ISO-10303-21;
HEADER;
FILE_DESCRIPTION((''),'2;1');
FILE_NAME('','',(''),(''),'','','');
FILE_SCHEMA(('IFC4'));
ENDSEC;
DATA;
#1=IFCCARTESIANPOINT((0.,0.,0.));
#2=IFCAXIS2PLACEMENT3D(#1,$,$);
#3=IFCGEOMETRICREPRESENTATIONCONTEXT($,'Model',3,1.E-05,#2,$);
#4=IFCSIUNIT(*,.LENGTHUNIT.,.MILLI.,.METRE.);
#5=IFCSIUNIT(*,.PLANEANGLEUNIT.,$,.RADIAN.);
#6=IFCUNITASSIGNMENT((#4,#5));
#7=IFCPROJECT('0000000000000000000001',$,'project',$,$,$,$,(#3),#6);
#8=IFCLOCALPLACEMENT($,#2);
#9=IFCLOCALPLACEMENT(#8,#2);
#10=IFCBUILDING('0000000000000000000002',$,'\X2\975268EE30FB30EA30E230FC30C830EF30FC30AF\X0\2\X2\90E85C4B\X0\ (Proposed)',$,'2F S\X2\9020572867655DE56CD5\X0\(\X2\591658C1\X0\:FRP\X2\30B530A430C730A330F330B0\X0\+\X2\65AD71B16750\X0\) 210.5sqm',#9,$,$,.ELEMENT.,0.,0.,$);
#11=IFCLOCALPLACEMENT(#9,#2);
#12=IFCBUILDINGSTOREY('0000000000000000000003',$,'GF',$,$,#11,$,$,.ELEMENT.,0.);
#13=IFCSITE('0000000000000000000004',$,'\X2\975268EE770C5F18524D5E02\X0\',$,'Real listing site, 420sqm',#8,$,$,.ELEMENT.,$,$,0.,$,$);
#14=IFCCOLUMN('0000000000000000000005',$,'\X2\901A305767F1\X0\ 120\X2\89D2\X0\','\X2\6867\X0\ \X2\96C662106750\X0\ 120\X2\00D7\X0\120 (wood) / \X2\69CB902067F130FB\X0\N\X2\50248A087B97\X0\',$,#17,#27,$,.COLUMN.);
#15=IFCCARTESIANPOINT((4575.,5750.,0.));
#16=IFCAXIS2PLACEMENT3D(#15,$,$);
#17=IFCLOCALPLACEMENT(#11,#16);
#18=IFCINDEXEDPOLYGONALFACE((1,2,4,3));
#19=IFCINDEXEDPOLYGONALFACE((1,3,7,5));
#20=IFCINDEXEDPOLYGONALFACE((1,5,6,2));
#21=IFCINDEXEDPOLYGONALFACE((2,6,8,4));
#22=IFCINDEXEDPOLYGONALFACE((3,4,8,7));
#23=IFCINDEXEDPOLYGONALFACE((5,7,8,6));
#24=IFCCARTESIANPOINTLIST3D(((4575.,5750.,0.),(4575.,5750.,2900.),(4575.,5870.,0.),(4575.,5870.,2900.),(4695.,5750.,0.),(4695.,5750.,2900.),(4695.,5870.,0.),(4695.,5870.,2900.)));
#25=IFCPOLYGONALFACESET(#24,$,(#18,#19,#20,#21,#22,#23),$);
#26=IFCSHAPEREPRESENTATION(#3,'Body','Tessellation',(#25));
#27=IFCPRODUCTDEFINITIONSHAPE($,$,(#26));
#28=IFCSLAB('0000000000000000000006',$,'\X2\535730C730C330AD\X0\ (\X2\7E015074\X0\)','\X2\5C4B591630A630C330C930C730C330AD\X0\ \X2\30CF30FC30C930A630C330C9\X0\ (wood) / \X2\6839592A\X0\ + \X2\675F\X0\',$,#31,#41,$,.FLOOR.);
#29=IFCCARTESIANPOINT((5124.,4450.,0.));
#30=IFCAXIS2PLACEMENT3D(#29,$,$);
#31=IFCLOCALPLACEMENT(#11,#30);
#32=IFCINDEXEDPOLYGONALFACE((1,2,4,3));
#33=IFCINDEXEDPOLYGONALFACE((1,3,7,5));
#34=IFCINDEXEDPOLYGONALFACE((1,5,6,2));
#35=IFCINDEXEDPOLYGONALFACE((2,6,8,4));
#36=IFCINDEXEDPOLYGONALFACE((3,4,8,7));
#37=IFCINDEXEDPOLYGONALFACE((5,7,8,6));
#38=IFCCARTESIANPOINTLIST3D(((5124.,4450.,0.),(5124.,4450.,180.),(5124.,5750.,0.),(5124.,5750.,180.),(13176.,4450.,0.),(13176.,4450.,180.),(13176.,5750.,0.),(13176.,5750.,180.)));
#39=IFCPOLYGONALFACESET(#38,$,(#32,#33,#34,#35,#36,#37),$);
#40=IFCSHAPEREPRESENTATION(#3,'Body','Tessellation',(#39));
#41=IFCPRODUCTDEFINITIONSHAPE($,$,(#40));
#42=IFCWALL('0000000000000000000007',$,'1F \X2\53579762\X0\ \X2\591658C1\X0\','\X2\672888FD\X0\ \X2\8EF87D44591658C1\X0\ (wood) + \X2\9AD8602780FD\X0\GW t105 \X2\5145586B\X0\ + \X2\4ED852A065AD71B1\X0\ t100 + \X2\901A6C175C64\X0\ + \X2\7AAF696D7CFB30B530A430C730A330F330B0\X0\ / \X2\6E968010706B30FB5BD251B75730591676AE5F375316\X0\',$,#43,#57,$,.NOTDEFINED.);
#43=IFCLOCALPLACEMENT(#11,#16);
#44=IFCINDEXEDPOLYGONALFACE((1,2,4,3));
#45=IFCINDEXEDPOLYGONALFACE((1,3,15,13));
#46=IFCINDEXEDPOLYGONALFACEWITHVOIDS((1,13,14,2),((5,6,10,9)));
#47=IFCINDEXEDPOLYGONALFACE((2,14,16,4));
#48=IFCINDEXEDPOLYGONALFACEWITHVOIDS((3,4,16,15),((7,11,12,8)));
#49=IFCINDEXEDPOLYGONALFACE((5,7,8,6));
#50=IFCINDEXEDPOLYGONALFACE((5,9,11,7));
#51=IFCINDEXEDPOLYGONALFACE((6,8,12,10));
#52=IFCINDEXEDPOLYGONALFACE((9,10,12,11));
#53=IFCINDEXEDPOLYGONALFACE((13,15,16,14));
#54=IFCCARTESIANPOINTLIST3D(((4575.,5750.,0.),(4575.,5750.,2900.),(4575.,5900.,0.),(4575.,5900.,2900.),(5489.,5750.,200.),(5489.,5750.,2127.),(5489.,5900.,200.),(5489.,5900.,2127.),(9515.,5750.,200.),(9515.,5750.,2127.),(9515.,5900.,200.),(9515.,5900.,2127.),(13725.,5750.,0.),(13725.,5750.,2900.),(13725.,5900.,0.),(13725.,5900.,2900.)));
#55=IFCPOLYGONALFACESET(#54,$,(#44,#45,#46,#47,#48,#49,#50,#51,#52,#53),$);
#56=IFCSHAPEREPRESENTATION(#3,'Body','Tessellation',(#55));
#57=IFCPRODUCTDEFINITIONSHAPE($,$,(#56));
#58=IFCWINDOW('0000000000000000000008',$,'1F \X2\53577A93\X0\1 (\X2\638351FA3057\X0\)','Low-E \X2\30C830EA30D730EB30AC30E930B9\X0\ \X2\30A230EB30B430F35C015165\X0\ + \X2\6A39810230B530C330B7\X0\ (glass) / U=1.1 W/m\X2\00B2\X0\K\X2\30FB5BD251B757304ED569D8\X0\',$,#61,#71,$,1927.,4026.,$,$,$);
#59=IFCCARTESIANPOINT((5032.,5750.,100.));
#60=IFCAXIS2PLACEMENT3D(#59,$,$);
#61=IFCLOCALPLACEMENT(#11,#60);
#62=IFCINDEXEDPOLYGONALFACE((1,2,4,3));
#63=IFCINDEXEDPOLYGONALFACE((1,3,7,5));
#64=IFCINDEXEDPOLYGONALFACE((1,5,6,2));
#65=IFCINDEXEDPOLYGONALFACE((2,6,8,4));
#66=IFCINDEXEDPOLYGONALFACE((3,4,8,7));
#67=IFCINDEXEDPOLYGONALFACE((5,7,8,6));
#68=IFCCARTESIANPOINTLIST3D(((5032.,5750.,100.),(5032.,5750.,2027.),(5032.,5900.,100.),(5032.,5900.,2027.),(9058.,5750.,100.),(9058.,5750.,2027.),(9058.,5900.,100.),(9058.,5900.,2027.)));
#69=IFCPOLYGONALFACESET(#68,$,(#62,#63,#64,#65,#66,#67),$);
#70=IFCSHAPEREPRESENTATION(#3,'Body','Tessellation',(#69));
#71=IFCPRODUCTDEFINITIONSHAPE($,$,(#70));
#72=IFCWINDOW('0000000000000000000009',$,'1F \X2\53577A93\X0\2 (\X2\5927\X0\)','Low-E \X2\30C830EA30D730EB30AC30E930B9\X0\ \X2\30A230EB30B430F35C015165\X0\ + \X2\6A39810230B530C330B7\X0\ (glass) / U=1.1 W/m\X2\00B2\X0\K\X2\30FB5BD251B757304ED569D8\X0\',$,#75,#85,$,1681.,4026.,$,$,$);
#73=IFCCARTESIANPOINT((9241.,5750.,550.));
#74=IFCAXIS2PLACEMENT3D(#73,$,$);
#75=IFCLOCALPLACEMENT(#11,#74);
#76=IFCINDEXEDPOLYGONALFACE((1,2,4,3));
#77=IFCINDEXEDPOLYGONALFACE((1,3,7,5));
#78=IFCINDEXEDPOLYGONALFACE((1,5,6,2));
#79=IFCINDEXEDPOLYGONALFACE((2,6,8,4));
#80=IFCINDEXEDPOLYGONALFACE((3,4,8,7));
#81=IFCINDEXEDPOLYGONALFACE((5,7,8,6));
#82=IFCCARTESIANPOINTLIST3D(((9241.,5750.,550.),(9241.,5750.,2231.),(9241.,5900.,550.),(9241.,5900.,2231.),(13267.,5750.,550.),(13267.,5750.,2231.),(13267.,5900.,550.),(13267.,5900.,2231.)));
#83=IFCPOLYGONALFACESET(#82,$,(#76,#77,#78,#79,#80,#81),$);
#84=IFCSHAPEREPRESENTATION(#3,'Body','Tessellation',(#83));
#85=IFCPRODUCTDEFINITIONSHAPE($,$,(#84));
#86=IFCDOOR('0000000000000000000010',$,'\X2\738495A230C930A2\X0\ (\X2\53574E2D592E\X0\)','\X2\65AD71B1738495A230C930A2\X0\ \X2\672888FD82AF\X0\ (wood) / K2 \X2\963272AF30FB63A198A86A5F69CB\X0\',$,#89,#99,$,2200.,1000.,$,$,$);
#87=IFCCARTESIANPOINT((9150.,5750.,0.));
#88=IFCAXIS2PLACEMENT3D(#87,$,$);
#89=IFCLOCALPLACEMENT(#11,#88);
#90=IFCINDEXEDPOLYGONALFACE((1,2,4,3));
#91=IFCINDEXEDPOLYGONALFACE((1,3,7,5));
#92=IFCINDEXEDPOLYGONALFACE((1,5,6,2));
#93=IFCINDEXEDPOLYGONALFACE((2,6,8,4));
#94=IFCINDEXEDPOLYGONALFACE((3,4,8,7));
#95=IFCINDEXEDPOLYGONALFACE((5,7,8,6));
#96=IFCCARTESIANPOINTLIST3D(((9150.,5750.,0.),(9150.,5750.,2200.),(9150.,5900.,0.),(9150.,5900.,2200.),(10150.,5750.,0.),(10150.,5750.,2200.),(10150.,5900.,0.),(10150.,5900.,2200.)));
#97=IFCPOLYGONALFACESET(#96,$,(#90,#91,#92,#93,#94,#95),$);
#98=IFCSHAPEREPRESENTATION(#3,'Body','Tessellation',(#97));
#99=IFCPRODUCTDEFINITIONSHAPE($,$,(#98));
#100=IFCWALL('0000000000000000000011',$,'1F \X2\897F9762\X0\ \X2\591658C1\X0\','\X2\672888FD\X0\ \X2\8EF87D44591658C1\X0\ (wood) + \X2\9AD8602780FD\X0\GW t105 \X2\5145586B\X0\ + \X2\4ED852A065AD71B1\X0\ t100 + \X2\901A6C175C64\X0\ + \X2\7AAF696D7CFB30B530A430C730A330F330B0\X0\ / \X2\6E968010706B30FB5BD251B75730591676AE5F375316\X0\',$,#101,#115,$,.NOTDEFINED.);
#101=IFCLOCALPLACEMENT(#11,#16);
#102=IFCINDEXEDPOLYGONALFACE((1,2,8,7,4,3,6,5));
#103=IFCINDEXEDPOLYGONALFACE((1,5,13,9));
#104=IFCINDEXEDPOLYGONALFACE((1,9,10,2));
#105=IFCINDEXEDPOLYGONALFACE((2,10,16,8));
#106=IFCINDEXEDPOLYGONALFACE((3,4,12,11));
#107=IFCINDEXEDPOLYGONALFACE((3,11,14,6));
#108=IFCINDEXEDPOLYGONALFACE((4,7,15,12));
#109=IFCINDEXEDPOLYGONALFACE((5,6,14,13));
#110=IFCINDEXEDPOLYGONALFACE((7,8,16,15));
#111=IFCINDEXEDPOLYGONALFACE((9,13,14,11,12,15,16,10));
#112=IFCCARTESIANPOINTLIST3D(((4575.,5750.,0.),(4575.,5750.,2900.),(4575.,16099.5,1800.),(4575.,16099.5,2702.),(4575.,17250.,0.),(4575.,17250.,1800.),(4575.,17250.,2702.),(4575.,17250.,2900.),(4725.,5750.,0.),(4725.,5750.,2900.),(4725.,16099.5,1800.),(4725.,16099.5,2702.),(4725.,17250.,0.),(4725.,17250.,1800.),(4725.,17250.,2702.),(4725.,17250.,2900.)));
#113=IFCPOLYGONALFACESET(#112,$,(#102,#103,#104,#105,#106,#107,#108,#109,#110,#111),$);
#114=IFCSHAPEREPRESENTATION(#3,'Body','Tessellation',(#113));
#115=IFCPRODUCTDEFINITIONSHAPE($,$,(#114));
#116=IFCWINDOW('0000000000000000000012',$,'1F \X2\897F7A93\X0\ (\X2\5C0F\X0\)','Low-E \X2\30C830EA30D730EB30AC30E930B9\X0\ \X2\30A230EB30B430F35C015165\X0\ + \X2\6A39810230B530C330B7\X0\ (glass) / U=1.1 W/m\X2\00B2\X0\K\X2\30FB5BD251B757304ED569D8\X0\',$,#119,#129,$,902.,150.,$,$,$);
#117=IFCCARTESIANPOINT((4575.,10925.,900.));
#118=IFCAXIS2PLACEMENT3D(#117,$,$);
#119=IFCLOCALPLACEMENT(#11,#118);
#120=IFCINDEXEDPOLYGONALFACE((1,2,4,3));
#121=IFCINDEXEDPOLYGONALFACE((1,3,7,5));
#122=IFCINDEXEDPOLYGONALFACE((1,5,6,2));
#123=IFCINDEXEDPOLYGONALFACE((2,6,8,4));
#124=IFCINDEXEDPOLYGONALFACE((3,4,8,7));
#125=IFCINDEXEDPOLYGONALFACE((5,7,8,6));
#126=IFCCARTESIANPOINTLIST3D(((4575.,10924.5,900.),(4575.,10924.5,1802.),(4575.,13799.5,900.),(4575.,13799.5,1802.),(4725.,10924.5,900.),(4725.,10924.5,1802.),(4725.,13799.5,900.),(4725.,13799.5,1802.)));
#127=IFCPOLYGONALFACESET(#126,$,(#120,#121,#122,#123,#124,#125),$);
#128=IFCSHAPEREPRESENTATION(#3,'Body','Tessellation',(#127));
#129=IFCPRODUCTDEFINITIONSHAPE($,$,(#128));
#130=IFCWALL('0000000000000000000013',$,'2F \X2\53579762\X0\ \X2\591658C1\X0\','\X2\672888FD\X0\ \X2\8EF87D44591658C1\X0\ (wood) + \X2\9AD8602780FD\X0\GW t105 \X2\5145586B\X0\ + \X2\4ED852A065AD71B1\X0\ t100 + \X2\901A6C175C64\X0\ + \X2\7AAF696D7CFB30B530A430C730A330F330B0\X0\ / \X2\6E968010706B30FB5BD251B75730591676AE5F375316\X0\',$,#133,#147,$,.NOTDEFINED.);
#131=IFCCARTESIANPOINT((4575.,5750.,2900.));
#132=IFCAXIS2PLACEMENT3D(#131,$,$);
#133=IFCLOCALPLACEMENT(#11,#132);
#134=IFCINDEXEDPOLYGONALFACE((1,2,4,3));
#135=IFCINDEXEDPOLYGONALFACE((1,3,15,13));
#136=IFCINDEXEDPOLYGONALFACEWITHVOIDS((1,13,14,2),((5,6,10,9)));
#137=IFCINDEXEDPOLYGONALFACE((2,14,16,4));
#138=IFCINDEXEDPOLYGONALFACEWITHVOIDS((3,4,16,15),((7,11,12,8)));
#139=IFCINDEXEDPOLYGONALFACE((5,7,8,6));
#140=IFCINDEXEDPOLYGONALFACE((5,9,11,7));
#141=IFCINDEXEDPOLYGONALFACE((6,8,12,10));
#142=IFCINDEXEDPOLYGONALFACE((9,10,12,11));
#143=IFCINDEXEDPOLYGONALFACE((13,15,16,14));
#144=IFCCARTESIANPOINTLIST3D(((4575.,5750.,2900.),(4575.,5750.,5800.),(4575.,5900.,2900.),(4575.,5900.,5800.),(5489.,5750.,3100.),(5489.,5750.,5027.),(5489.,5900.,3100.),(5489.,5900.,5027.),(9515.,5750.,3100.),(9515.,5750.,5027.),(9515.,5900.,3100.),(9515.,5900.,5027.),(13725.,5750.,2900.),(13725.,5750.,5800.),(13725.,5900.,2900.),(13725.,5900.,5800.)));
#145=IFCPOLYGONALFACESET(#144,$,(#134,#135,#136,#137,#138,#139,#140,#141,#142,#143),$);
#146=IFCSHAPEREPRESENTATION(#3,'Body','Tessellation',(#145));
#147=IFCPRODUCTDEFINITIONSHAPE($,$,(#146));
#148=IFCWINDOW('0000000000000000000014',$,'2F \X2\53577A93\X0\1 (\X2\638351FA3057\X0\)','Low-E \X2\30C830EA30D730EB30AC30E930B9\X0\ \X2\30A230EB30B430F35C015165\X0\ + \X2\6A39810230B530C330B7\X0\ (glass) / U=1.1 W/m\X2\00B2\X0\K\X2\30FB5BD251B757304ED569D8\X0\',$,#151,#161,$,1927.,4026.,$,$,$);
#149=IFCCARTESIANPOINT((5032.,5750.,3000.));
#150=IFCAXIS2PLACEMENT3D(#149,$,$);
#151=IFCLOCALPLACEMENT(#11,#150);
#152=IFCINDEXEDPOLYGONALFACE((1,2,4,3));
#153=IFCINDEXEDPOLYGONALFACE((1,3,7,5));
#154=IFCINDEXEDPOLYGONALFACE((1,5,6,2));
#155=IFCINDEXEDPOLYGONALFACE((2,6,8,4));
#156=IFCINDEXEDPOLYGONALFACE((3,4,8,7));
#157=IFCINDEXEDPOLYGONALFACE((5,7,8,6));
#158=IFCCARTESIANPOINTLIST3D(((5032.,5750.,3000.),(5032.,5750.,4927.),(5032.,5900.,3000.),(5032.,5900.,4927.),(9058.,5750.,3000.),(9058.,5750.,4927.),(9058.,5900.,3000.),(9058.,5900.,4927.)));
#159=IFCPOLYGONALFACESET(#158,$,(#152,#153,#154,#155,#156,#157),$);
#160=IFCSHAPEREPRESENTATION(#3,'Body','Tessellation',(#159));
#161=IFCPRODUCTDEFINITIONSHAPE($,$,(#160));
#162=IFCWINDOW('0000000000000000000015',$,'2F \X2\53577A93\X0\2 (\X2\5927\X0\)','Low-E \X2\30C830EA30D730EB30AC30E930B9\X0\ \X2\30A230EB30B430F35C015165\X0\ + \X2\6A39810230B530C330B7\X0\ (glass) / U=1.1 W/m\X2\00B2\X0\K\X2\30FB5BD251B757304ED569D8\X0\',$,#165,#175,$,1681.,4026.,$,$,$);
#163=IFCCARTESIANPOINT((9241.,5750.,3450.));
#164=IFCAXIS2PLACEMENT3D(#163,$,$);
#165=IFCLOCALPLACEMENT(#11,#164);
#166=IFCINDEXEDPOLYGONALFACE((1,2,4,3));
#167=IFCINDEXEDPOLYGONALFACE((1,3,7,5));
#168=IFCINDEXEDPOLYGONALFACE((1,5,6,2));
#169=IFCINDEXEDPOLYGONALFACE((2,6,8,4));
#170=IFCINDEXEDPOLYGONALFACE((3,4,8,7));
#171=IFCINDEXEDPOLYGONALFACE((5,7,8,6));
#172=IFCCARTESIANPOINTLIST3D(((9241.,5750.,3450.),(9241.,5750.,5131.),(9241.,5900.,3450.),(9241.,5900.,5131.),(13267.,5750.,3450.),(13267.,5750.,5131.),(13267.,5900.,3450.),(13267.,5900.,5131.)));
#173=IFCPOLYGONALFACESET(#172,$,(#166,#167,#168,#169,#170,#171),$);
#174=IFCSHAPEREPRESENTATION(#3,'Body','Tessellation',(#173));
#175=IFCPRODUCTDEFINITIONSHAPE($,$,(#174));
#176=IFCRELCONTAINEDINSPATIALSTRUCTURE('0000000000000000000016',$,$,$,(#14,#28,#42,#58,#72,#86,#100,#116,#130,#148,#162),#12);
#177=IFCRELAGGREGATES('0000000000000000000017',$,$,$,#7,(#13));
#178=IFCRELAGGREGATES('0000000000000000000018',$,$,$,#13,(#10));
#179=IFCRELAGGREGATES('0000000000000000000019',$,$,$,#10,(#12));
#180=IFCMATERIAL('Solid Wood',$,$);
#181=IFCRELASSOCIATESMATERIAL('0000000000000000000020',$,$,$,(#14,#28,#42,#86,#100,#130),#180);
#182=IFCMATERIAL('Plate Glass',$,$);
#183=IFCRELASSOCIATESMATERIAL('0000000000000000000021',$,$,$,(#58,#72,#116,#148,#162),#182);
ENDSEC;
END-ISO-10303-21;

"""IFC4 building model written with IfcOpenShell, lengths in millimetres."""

from ifc_helpers import new_model, si_unit, frame, frame_2d, origin, place, context, project, spatial, rectangle, extrude, material, element, fill, save


model = new_model("IFC4")

# Units and contexts
model_context = context("Model", 3, precision=1e-05, world=origin())
ifc_project = project(units=[si_unit("LENGTHUNIT", "METRE", prefix="MILLI"), si_unit("PLANEANGLEUNIT", "RADIAN")], contexts=[model_context])

# Site, building, storey
site_placement = place(None, origin())
site = spatial("IfcSite", under=ifc_project, at=site_placement, Name="青森県弘前市", ObjectType="Real listing site, 420sqm", CompositionType="ELEMENT", RefElevation=0.0)
building_placement = place(site_placement, origin())
building = spatial("IfcBuilding", under=site, at=building_placement, Name="青森・リモートワーク2部屋 (Proposed)", ObjectType="2F S造在来工法(外壁:FRPサイディング+断熱材) 210.5sqm", CompositionType="ELEMENT", ElevationOfRefHeight=0.0, ElevationOfTerrain=0.0)
storey_placement = place(building_placement, origin())
storey = spatial("IfcBuildingStorey", under=building, at=storey_placement, Name="GF", CompositionType="ELEMENT", Elevation=0.0)

# Column
ifc_material_1 = material(Name="Solid Wood")
column_placement = place(storey_placement, frame((4575.0, 5750.0, 0.0)))
element("IfcColumn", 1, at=column_placement, inside=storey, material=ifc_material_1, Name="通し柱 120角", Description="桧 集成材 120×120 (wood) / 構造柱・N値計算", PredefinedType="COLUMN", context=model_context, shape_type="SweptSolid", body=[
    extrude(rectangle(XDim=120.0, YDim=120.0, at=frame_2d((60.0, 60.0))), frame((4575.0, 5750.0, 0.0)), (0.0, 0.0, 1.0), 2900.0),
])

# Slab
slab_1_placement = place(storey_placement, frame((5124.0, 4450.0, 0.0)))
element("IfcSlab", 2, at=slab_1_placement, inside=storey, material=ifc_material_1, Name="南デッキ (縁側)", Description="屋外ウッドデッキ ハードウッド (wood) / 根太 + 束", PredefinedType="FLOOR", context=model_context, shape_type="SweptSolid", body=[
    extrude(rectangle(XDim=8052.0, YDim=1300.0, at=frame_2d((4026.0, 650.0))), frame((5124.0, 4450.0, 0.0)), (0.0, 0.0, 1.0), 180.0),
])

# Wall, openings, windows, door
wall_1_placement = place(storey_placement, frame((4575.0, 5750.0, 0.0)))
wall_1 = element("IfcWall", 3, at=wall_1_placement, inside=storey, material=ifc_material_1, Name="1F 南面 外壁", Description="木製 軸組外壁 (wood) + 高性能GW t105 充填 + 付加断熱 t100 + 通気層 + 窯業系サイディング / 準耐火・寒冷地外皮強化", PredefinedType="NOTDEFINED", context=model_context, shape_type="SweptSolid", body=[
    extrude(rectangle(XDim=9150.0, YDim=150.0, at=frame_2d((4575.0, 75.0))), frame((4575.0, 5750.0, 0.0)), (0.0, 0.0, 1.0), 2900.0),
])
opening_1_placement = place(storey_placement, frame((5032.0, 5750.0, 100.0)))
opening_1 = element("IfcOpeningElement", 4, at=opening_1_placement, cuts=wall_1, PredefinedType="NOTDEFINED", context=model_context, shape_type="SweptSolid", body=[
    extrude(rectangle(XDim=4026.0, YDim=150.0, at=frame_2d((2013.0, 75.0))), frame((5032.0, 5750.0, 100.0)), (0.0, 0.0, 1.0), 1927.0),
])
opening_2_placement = place(storey_placement, frame((9241.0, 5750.0, 550.0)))
opening_2 = element("IfcOpeningElement", 5, at=opening_2_placement, cuts=wall_1, PredefinedType="NOTDEFINED", context=model_context, shape_type="SweptSolid", body=[
    extrude(rectangle(XDim=4026.0, YDim=150.0, at=frame_2d((2013.0, 75.0))), frame((9241.0, 5750.0, 550.0)), (0.0, 0.0, 1.0), 1681.0),
])
opening_3_placement = place(storey_placement, frame((9150.0, 5750.0, 0.0)))
opening_3 = element("IfcOpeningElement", 6, at=opening_3_placement, cuts=wall_1, PredefinedType="NOTDEFINED", context=model_context, shape_type="SweptSolid", body=[
    extrude(rectangle(XDim=1000.0, YDim=150.0, at=frame_2d((500.0, 75.0))), frame((9150.0, 5750.0, 0.0)), (0.0, 0.0, 1.0), 2200.0),
])
ifc_material_2 = material(Name="Plate Glass")
window_1_placement = place(storey_placement, frame((5032.0, 5750.0, 100.0)))
window_1 = element("IfcWindow", 7, at=window_1_placement, inside=storey, material=ifc_material_2, Name="1F 南窓1 (掃出し)", Description="Low-E トリプルガラス アルゴン封入 + 樹脂サッシ (glass) / U=1.1 W/m²K・寒冷地仕様", OverallHeight=1927.0, OverallWidth=4026.0, context=model_context, shape_type="SweptSolid", body=[
    extrude(rectangle(XDim=4026.0, YDim=150.0, at=frame_2d((2013.0, 75.0))), frame((5032.0, 5750.0, 100.0)), (0.0, 0.0, 1.0), 1927.0),
])
fill(opening_1, window_1)
window_2_placement = place(storey_placement, frame((9241.0, 5750.0, 550.0)))
window_2 = element("IfcWindow", 8, at=window_2_placement, inside=storey, material=ifc_material_2, Name="1F 南窓2 (大)", Description="Low-E トリプルガラス アルゴン封入 + 樹脂サッシ (glass) / U=1.1 W/m²K・寒冷地仕様", OverallHeight=1681.0, OverallWidth=4026.0, context=model_context, shape_type="SweptSolid", body=[
    extrude(rectangle(XDim=4026.0, YDim=150.0, at=frame_2d((2013.0, 75.0))), frame((9241.0, 5750.0, 550.0)), (0.0, 0.0, 1.0), 1681.0),
])
fill(opening_2, window_2)
door_placement = place(storey_placement, frame((9150.0, 5750.0, 0.0)))
door = element("IfcDoor", 9, at=door_placement, inside=storey, material=ifc_material_1, Name="玄関ドア (南中央)", Description="断熱玄関ドア 木製芯 (wood) / K2 防犯・採風機構", OverallHeight=2200.0, OverallWidth=1000.0, context=model_context, shape_type="SweptSolid", body=[
    extrude(rectangle(XDim=1000.0, YDim=150.0, at=frame_2d((500.0, 75.0))), frame((9150.0, 5750.0, 0.0)), (0.0, 0.0, 1.0), 2200.0),
])
fill(opening_3, door)

# Wall, opening, window
wall_2_placement = place(storey_placement, frame((4575.0, 5750.0, 0.0)))
wall_2 = element("IfcWall", 10, at=wall_2_placement, inside=storey, material=ifc_material_1, Name="1F 西面 外壁", Description="木製 軸組外壁 (wood) + 高性能GW t105 充填 + 付加断熱 t100 + 通気層 + 窯業系サイディング / 準耐火・寒冷地外皮強化", PredefinedType="NOTDEFINED", context=model_context, shape_type="SweptSolid", body=[
    extrude(rectangle(XDim=150.0, YDim=11500.0, at=frame_2d((75.0, 5750.0))), frame((4575.0, 5750.0, 0.0)), (0.0, 0.0, 1.0), 2900.0),
])
opening_4_placement = place(storey_placement, frame((4575.0, 10925.0, 900.0)))
opening_4 = element("IfcOpeningElement", 11, at=opening_4_placement, cuts=wall_2, PredefinedType="NOTDEFINED", context=model_context, shape_type="SweptSolid", body=[
    extrude(rectangle(XDim=150.0, YDim=2875.0, at=frame_2d((75.0, 1437.0))), frame((4575.0, 10925.0, 900.0)), (0.0, 0.0, 1.0), 902.0),
])
window_3_placement = place(storey_placement, frame((4575.0, 10925.0, 900.0)))
window_3 = element("IfcWindow", 12, at=window_3_placement, inside=storey, material=ifc_material_2, Name="1F 西窓 (小)", Description="Low-E トリプルガラス アルゴン封入 + 樹脂サッシ (glass) / U=1.1 W/m²K・寒冷地仕様", OverallHeight=902.0, OverallWidth=150.0, context=model_context, shape_type="SweptSolid", body=[
    extrude(rectangle(XDim=150.0, YDim=2875.0, at=frame_2d((75.0, 1437.0))), frame((4575.0, 10925.0, 900.0)), (0.0, 0.0, 1.0), 902.0),
])
fill(opening_4, window_3)

# Wall, openings, windows
wall_3_placement = place(storey_placement, frame((4575.0, 5750.0, 2900.0)))
wall_3 = element("IfcWall", 13, at=wall_3_placement, inside=storey, material=ifc_material_1, Name="2F 南面 外壁", Description="木製 軸組外壁 (wood) + 高性能GW t105 充填 + 付加断熱 t100 + 通気層 + 窯業系サイディング / 準耐火・寒冷地外皮強化", PredefinedType="NOTDEFINED", context=model_context, shape_type="SweptSolid", body=[
    extrude(rectangle(XDim=9150.0, YDim=150.0, at=frame_2d((4575.0, 75.0))), frame((4575.0, 5750.0, 2900.0)), (0.0, 0.0, 1.0), 2900.0),
])
opening_5_placement = place(storey_placement, frame((5032.0, 5750.0, 3000.0)))
opening_5 = element("IfcOpeningElement", 14, at=opening_5_placement, cuts=wall_3, PredefinedType="NOTDEFINED", context=model_context, shape_type="SweptSolid", body=[
    extrude(rectangle(XDim=4026.0, YDim=150.0, at=frame_2d((2013.0, 75.0))), frame((5032.0, 5750.0, 3000.0)), (0.0, 0.0, 1.0), 1927.0),
])
opening_6_placement = place(storey_placement, frame((9241.0, 5750.0, 3450.0)))
opening_6 = element("IfcOpeningElement", 15, at=opening_6_placement, cuts=wall_3, PredefinedType="NOTDEFINED", context=model_context, shape_type="SweptSolid", body=[
    extrude(rectangle(XDim=4026.0, YDim=150.0, at=frame_2d((2013.0, 75.0))), frame((9241.0, 5750.0, 3450.0)), (0.0, 0.0, 1.0), 1681.0),
])
window_4_placement = place(storey_placement, frame((5032.0, 5750.0, 3000.0)))
window_4 = element("IfcWindow", 16, at=window_4_placement, inside=storey, material=ifc_material_2, Name="2F 南窓1 (掃出し)", Description="Low-E トリプルガラス アルゴン封入 + 樹脂サッシ (glass) / U=1.1 W/m²K・寒冷地仕様", OverallHeight=1927.0, OverallWidth=4026.0, context=model_context, shape_type="SweptSolid", body=[
    extrude(rectangle(XDim=4026.0, YDim=150.0, at=frame_2d((2013.0, 75.0))), frame((5032.0, 5750.0, 3000.0)), (0.0, 0.0, 1.0), 1927.0),
])
fill(opening_5, window_4)
window_5_placement = place(storey_placement, frame((9241.0, 5750.0, 3450.0)))
window_5 = element("IfcWindow", 17, at=window_5_placement, inside=storey, material=ifc_material_2, Name="2F 南窓2 (大)", Description="Low-E トリプルガラス アルゴン封入 + 樹脂サッシ (glass) / U=1.1 W/m²K・寒冷地仕様", OverallHeight=1681.0, OverallWidth=4026.0, context=model_context, shape_type="SweptSolid", body=[
    extrude(rectangle(XDim=4026.0, YDim=150.0, at=frame_2d((2013.0, 75.0))), frame((9241.0, 5750.0, 3450.0)), (0.0, 0.0, 1.0), 1681.0),
])
fill(opening_6, window_5)

save(model, "model.ifc")
